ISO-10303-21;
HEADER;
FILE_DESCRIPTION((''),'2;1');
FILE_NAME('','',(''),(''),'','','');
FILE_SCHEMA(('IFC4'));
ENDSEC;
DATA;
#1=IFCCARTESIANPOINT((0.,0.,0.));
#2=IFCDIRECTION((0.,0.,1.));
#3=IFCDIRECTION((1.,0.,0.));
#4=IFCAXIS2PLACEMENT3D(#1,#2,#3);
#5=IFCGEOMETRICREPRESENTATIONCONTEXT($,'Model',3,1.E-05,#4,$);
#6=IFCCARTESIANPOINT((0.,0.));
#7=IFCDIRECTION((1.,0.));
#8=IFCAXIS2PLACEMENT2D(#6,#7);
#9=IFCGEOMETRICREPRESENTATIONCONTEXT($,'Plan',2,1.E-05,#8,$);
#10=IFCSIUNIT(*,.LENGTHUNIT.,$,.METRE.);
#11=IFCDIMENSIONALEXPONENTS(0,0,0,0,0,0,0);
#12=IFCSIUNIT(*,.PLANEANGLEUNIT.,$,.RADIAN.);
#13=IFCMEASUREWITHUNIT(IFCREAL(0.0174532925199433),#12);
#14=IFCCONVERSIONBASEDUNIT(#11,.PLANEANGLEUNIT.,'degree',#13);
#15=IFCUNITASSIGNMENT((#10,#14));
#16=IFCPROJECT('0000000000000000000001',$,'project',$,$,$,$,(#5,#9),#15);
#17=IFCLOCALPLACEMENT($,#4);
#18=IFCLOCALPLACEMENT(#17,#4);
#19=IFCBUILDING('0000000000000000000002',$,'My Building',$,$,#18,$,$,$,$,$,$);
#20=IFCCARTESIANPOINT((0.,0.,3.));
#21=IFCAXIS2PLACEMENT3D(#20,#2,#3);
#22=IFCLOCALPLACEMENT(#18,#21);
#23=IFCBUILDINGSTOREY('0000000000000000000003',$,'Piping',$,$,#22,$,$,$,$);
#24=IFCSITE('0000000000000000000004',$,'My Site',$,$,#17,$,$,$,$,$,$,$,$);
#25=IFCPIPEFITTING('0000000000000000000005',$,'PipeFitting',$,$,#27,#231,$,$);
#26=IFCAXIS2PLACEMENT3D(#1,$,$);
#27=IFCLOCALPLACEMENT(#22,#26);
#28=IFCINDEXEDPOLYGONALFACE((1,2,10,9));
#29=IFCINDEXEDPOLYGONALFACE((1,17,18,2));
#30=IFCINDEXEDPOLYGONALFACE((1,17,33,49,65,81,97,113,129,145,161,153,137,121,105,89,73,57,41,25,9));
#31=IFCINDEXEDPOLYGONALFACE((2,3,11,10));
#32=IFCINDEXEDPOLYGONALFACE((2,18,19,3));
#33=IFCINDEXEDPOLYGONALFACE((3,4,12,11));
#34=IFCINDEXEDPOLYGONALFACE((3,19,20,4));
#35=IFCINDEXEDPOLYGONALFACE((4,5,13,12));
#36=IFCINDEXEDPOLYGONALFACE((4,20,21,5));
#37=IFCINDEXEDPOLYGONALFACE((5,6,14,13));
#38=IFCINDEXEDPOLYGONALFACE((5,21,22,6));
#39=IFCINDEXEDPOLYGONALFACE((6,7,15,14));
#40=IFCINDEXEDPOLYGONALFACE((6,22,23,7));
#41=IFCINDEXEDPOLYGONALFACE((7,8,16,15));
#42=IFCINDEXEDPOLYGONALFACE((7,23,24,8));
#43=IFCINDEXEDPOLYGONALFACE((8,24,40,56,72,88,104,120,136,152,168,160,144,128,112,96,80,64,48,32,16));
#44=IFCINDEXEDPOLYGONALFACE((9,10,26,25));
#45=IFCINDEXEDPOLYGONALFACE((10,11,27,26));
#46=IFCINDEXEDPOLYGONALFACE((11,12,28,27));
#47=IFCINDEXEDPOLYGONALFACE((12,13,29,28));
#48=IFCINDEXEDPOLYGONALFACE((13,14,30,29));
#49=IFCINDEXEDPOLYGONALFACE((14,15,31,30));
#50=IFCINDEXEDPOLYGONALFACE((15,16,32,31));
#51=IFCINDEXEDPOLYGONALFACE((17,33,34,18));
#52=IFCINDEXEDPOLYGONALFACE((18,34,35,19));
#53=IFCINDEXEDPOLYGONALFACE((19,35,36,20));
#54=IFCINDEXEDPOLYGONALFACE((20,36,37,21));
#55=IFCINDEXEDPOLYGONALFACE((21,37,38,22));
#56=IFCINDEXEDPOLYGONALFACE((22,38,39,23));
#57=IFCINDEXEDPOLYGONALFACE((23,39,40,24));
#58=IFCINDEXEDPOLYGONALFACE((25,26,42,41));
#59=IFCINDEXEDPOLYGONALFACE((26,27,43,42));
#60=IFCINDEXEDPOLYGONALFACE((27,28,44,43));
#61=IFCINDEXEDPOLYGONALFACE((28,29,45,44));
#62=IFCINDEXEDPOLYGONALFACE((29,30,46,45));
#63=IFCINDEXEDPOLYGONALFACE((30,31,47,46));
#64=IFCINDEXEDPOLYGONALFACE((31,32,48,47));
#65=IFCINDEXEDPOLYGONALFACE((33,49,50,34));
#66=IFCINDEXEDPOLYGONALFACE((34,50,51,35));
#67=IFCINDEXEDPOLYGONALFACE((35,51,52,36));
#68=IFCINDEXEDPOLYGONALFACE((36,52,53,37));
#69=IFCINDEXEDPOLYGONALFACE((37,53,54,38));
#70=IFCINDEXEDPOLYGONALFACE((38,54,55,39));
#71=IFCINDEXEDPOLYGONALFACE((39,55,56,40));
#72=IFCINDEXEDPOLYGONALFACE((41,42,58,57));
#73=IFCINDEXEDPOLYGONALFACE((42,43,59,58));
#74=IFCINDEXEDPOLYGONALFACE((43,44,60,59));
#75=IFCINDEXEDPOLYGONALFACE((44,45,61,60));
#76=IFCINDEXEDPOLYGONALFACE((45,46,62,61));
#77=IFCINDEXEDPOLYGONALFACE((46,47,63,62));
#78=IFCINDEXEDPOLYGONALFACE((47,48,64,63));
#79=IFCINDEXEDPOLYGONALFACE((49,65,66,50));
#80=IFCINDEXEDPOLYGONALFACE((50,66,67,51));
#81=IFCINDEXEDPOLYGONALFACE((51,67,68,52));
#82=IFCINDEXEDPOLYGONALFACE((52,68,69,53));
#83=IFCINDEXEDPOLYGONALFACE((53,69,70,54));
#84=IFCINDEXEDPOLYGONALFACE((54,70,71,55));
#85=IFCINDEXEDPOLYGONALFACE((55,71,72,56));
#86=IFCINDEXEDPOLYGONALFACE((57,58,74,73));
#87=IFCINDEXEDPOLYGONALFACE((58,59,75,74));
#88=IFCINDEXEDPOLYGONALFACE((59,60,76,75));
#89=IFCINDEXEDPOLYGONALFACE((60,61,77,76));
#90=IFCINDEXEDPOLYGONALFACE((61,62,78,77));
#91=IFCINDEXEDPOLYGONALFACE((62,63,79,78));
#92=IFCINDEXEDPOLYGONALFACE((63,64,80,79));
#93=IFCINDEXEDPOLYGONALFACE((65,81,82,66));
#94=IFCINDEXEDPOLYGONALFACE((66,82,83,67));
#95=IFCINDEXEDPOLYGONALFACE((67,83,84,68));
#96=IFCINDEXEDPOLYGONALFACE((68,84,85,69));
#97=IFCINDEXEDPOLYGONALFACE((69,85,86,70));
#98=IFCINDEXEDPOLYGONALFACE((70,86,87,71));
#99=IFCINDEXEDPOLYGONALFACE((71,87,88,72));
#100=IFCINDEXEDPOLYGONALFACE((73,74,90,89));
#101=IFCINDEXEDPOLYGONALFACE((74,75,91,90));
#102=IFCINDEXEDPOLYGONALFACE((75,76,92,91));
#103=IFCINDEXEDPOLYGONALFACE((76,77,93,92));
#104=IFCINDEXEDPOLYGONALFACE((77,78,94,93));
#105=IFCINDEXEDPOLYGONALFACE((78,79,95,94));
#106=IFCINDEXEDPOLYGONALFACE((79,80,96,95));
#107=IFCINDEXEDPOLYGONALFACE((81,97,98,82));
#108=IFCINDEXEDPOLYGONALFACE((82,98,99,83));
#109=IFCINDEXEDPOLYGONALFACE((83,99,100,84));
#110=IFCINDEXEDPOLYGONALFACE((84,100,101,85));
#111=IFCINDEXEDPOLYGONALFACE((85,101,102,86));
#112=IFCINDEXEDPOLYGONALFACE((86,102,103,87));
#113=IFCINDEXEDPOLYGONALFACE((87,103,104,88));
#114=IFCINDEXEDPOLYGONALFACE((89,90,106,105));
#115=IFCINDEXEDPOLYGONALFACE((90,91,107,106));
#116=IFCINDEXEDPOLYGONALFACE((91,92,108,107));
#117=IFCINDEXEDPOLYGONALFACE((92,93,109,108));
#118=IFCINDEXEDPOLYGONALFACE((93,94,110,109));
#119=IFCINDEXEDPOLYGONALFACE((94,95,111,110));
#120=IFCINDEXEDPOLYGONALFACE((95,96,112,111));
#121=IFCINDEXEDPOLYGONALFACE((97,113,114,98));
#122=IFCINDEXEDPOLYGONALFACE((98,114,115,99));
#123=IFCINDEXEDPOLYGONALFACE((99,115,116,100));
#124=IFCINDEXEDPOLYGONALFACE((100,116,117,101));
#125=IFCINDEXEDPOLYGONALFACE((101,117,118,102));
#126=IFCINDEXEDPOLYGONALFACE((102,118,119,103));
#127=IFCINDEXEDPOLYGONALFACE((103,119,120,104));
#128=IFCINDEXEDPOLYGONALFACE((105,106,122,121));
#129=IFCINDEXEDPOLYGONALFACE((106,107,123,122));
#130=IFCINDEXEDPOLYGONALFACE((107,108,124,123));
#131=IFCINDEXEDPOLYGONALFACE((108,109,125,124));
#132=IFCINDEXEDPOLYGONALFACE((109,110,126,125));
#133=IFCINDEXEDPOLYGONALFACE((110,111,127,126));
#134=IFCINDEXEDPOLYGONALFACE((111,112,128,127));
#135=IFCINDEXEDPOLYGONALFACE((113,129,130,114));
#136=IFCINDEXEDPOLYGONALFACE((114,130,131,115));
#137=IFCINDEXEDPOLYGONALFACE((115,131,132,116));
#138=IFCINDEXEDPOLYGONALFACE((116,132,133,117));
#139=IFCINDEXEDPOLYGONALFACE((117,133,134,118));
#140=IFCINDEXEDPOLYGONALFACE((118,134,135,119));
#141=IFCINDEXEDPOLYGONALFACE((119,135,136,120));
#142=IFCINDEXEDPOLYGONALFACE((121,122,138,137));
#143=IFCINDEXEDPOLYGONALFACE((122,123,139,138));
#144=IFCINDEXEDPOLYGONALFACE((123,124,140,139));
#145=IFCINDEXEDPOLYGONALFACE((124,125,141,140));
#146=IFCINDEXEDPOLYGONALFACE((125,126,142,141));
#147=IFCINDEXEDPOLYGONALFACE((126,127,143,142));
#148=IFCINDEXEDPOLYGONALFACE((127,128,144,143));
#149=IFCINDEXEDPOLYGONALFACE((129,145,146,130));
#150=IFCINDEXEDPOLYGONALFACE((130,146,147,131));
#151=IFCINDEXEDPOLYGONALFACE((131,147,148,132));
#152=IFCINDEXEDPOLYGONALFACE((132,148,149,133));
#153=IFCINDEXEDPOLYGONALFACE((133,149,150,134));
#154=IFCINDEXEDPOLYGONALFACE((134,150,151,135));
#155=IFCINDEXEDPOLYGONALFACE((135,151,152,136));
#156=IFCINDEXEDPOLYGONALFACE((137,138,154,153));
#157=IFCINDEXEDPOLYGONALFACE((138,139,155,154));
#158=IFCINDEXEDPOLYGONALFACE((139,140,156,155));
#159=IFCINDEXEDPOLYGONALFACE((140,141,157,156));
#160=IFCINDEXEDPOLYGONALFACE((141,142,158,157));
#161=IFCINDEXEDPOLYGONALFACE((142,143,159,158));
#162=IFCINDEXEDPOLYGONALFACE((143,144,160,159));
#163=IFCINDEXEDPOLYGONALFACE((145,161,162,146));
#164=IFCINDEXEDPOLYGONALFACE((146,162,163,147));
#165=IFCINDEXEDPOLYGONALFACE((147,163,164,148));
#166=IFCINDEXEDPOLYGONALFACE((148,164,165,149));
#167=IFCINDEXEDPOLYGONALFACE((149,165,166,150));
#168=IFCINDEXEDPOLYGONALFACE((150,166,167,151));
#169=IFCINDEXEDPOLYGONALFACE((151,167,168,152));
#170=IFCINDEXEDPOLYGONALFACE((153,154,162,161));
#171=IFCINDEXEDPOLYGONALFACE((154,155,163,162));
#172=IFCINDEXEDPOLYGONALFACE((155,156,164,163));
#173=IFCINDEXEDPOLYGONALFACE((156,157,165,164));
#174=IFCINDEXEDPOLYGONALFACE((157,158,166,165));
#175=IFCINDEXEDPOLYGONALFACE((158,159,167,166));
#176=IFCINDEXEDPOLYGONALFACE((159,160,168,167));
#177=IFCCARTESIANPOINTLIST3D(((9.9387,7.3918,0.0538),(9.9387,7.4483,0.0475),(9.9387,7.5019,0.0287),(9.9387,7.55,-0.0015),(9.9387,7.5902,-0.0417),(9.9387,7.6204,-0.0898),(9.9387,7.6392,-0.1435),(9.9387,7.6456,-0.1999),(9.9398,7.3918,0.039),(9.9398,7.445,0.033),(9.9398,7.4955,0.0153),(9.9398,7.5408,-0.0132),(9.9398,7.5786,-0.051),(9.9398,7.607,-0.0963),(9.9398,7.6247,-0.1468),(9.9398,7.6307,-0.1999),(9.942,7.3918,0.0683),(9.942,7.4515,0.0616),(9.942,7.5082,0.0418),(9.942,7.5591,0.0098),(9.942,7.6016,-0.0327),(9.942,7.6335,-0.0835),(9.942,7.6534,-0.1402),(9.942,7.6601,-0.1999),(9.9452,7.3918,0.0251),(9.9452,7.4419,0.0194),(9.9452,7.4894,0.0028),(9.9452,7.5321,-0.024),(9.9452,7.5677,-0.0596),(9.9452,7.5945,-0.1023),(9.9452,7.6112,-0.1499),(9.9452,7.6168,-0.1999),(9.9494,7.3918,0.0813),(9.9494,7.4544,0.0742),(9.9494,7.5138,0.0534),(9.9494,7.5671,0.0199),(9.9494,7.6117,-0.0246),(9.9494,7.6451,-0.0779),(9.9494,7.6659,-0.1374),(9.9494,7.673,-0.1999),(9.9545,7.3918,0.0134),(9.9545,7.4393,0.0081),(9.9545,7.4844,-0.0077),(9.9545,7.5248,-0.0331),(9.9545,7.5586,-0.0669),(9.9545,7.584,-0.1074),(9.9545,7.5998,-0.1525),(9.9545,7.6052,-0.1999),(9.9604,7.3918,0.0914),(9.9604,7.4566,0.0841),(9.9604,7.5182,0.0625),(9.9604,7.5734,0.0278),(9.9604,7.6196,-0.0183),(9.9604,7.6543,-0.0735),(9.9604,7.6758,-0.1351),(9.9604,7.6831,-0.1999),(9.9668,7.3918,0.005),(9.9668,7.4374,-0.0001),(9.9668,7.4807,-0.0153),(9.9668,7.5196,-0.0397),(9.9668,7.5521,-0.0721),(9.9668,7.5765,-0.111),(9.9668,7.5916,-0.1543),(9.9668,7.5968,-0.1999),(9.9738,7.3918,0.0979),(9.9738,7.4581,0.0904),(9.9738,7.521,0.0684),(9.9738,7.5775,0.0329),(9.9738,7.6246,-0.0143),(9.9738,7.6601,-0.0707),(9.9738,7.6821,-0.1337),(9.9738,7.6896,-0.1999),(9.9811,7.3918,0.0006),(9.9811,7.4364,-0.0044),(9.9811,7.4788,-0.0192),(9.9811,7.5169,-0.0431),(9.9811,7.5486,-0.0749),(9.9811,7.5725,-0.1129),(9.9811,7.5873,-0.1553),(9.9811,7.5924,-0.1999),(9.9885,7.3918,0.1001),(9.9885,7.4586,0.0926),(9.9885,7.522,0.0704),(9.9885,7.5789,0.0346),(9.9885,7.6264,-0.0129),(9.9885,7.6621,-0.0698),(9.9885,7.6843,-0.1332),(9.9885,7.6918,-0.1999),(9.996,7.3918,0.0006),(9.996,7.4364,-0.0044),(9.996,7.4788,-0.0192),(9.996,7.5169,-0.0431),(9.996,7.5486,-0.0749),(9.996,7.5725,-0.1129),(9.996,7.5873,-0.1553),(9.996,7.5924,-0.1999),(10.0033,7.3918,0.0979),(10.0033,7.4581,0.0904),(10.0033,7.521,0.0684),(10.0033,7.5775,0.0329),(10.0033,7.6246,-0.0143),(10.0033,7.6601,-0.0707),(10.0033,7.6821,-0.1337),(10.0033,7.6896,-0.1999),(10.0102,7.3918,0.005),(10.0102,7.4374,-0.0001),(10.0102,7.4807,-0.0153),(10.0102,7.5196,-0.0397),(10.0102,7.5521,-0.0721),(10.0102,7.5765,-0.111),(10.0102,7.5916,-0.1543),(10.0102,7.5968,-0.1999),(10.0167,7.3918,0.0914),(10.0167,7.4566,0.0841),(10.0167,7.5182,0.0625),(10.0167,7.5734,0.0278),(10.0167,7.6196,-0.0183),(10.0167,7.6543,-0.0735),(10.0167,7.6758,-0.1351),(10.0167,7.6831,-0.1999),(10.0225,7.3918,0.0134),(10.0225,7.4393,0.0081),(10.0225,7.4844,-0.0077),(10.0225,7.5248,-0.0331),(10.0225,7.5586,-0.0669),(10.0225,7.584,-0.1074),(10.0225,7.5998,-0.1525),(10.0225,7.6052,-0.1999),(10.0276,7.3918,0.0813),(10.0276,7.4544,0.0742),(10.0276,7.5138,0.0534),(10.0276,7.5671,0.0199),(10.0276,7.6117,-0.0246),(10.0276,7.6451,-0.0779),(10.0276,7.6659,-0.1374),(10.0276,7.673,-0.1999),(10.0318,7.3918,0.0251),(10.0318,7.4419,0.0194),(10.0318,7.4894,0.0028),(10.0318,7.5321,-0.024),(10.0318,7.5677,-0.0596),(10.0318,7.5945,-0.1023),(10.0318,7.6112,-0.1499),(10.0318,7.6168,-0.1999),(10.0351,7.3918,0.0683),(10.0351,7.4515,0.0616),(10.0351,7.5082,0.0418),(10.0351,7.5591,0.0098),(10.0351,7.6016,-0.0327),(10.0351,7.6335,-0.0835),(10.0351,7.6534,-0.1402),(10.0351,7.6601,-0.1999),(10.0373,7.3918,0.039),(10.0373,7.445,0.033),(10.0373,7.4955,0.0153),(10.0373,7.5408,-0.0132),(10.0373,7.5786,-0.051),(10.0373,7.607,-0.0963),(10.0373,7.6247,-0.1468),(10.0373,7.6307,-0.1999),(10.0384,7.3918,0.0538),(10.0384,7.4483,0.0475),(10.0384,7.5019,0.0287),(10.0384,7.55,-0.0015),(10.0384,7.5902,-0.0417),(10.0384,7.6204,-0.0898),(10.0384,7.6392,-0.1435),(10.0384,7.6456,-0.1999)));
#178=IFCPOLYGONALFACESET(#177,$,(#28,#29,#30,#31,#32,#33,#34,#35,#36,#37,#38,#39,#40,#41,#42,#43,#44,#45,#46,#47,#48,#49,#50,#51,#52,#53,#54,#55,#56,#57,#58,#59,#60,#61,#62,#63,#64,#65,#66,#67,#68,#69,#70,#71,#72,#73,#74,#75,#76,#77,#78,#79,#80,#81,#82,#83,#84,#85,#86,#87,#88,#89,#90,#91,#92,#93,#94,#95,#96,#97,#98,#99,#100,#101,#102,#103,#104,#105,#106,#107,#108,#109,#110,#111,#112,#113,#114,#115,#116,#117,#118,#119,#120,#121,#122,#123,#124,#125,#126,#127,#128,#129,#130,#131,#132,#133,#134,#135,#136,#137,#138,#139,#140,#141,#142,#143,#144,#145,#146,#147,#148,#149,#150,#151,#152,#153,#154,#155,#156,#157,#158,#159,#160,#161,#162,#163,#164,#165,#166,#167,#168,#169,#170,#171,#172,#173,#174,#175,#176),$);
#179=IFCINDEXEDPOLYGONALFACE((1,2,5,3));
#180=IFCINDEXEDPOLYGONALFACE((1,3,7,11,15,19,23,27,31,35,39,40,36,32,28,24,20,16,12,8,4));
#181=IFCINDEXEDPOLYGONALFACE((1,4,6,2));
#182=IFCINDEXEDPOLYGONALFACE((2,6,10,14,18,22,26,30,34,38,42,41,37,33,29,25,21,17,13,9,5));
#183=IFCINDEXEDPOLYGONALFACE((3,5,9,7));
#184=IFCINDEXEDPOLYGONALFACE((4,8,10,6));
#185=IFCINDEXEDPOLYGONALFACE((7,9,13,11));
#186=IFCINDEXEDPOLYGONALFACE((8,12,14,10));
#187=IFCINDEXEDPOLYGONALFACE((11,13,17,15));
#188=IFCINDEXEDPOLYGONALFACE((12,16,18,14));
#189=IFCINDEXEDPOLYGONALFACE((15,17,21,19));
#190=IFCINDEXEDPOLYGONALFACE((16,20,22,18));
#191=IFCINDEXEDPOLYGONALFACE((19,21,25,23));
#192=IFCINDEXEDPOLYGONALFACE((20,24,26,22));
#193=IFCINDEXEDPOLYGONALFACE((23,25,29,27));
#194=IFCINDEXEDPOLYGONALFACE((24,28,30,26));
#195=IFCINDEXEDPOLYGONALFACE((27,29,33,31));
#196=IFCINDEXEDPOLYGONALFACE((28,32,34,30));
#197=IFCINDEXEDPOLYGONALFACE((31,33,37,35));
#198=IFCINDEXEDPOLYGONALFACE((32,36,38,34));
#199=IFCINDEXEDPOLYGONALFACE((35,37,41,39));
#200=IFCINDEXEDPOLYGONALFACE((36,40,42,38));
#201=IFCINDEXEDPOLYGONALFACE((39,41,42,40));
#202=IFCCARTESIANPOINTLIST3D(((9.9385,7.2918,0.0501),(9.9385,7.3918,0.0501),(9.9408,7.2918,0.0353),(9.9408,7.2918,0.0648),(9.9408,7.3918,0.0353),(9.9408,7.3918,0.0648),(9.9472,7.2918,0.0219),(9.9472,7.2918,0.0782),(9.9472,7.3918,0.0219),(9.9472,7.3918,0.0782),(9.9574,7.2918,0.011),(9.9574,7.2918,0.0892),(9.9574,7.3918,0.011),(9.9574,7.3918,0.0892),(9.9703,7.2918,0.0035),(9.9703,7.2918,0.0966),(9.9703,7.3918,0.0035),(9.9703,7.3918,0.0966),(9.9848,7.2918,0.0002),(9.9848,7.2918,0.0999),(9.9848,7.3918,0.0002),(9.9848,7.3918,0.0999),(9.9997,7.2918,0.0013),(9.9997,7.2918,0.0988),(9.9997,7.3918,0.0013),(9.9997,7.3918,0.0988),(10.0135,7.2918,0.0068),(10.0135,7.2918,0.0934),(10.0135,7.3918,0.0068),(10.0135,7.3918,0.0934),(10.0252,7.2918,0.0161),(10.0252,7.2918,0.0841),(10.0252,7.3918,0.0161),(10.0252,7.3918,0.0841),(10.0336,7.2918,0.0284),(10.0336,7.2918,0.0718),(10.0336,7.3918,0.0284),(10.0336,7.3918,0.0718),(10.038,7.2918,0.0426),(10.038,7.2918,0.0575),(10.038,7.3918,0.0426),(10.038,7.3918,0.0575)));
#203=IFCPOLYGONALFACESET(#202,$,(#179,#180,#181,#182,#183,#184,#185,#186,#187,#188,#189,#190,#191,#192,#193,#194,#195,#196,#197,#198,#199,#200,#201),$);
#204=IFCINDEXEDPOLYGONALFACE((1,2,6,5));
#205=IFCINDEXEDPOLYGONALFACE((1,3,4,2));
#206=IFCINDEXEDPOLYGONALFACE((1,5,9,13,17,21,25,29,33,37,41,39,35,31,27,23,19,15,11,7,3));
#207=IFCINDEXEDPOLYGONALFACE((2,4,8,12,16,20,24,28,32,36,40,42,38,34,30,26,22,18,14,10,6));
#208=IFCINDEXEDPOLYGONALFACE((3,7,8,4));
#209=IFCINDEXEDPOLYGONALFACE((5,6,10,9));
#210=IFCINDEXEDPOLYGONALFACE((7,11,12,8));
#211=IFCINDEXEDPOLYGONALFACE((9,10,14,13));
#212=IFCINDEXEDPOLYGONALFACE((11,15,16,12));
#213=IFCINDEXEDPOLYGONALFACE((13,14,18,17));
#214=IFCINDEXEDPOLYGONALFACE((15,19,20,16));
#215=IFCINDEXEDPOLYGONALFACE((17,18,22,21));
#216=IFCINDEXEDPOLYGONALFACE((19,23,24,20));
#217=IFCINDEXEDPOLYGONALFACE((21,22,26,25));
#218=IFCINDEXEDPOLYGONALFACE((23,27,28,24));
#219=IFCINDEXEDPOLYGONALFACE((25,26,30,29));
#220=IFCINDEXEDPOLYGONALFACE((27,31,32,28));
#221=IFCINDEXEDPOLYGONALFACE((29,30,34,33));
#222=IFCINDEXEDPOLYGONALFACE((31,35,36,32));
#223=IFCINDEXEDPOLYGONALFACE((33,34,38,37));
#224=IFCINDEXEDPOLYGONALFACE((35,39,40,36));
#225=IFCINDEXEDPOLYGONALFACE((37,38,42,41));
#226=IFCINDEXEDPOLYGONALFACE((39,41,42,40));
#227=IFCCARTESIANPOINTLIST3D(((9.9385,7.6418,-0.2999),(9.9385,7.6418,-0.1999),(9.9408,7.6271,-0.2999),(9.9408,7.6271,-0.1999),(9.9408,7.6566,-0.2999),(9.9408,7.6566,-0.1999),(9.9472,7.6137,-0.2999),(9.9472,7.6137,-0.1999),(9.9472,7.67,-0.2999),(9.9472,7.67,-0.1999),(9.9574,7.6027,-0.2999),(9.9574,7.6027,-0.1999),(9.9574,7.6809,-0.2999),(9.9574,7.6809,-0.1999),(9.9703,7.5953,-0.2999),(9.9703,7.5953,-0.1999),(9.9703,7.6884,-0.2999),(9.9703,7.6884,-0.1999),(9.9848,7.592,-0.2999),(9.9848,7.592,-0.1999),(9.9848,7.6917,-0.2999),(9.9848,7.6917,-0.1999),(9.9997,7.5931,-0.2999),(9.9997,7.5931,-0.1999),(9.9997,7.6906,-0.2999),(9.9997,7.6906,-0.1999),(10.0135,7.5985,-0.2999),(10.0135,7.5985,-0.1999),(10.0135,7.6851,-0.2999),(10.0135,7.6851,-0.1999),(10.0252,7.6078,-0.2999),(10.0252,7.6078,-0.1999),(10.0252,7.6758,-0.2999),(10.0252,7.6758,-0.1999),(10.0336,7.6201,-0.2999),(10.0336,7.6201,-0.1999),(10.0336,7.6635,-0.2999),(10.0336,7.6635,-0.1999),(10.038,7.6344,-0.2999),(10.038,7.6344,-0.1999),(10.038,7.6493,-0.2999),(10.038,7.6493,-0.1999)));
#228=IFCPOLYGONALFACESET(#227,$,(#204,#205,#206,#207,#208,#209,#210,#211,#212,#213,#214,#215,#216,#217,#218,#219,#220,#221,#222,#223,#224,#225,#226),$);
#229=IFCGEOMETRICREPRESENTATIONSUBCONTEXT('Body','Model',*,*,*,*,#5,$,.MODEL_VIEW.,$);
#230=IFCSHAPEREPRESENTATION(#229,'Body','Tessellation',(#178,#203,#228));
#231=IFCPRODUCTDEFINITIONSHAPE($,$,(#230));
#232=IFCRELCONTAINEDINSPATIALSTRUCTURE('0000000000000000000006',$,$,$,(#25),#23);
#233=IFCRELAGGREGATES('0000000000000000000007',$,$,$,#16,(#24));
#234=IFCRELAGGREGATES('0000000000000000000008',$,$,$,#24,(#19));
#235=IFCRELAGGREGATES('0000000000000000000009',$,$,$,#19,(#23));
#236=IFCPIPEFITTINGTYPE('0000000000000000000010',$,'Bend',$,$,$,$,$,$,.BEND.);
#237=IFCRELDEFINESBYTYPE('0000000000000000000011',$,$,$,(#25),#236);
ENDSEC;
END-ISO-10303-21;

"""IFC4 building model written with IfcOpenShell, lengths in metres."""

from ifc_helpers import new_model, entity, si_unit, converted_unit, frame, origin_with_axes, origin_2d_with_axis, place, context, subcontext, project, spatial, circle, extrude, source, transform, mapped, type_object, type_shapes, element, save


model = new_model("IFC4")

# Units and contexts
model_context = context("Model", 3, precision=1e-05, world=origin_with_axes())
plan_context = context("Plan", 2, precision=1e-05, world=origin_2d_with_axis())
body_context = subcontext(model_context, "Body", "Model", "MODEL_VIEW")
ifc_project = project(units=[si_unit("LENGTHUNIT", "METRE"), converted_unit("PLANEANGLEUNIT", "degree", entity("IfcReal", 0.0174532925199433), si_unit("PLANEANGLEUNIT", "RADIAN"), dimensions=[0, 0, 0, 0, 0, 0, 0])], contexts=[model_context, plan_context])

# Site, building, storey
site_placement = place(None, origin_with_axes())
site = spatial("IfcSite", under=ifc_project, at=site_placement, Name="My Site")
building_placement = place(site_placement, origin_with_axes())
building = spatial("IfcBuilding", under=site, at=building_placement, Name="My Building")
storey_placement = place(building_placement, frame((0.0, 0.0, 3.0), z_axis=(0.0, 0.0, 1.0), x_axis=(1.0, 0.0, 0.0)))
storey = spatial("IfcBuildingStorey", under=building, at=storey_placement, Name="Piping")

# Pipe fitting
pipe_fitting_type_1 = type_object("IfcPipeFittingType", Name="Bend", PredefinedType="BEND")
shared_shape = source(origin_with_axes(), body_context, "Body", "SolidModel", [
    entity("IfcSweptDiskSolid", entity("IfcIndexedPolyCurve", entity("IfcCartesianPointList3D", [[0.0, 0.0, 0.1], [0.0, -0.0732, 0.2768], [0.0, -0.25, 0.35]]), [entity("IfcArcIndex", [1, 2, 3])]), 0.05),
    extrude(circle(Radius=0.05), origin_with_axes(), (0.0, 0.0, 1.0), 0.1),
    extrude(circle(Radius=0.05), frame((0.0, -0.25, 0.35), z_axis=(0.0, -1.0, -0.000003), x_axis=(1.0, 0.0, 0.0)), (0.0, 0.0, 1.0), 0.1),
])
type_shapes(pipe_fitting_type_1, [shared_shape])
for number, where, z_axis, x_axis, name in (
    (1, (9.9885, 7.2918, 0.0501), (0.0, 1.0, 0.0), (-1.0, 0.0, 0.0), "PipeFitting"),
):
    element("IfcPipeFitting", number, at=place(storey_placement, frame(where, z_axis=z_axis, x_axis=x_axis)), inside=storey, type_object=pipe_fitting_type_1, Name=name, context=body_context, shape_type="MappedRepresentation", body=[
        mapped(shared_shape, transform((0.0, 0.0, 0.0), x_axis=(1.0, 0.0, 0.0), y_axis=(0.0, 1.0, 0.0), z_axis=(0.0, 0.0, 1.0), scale=1.0)),
    ])

save(model, "model.ifc")
